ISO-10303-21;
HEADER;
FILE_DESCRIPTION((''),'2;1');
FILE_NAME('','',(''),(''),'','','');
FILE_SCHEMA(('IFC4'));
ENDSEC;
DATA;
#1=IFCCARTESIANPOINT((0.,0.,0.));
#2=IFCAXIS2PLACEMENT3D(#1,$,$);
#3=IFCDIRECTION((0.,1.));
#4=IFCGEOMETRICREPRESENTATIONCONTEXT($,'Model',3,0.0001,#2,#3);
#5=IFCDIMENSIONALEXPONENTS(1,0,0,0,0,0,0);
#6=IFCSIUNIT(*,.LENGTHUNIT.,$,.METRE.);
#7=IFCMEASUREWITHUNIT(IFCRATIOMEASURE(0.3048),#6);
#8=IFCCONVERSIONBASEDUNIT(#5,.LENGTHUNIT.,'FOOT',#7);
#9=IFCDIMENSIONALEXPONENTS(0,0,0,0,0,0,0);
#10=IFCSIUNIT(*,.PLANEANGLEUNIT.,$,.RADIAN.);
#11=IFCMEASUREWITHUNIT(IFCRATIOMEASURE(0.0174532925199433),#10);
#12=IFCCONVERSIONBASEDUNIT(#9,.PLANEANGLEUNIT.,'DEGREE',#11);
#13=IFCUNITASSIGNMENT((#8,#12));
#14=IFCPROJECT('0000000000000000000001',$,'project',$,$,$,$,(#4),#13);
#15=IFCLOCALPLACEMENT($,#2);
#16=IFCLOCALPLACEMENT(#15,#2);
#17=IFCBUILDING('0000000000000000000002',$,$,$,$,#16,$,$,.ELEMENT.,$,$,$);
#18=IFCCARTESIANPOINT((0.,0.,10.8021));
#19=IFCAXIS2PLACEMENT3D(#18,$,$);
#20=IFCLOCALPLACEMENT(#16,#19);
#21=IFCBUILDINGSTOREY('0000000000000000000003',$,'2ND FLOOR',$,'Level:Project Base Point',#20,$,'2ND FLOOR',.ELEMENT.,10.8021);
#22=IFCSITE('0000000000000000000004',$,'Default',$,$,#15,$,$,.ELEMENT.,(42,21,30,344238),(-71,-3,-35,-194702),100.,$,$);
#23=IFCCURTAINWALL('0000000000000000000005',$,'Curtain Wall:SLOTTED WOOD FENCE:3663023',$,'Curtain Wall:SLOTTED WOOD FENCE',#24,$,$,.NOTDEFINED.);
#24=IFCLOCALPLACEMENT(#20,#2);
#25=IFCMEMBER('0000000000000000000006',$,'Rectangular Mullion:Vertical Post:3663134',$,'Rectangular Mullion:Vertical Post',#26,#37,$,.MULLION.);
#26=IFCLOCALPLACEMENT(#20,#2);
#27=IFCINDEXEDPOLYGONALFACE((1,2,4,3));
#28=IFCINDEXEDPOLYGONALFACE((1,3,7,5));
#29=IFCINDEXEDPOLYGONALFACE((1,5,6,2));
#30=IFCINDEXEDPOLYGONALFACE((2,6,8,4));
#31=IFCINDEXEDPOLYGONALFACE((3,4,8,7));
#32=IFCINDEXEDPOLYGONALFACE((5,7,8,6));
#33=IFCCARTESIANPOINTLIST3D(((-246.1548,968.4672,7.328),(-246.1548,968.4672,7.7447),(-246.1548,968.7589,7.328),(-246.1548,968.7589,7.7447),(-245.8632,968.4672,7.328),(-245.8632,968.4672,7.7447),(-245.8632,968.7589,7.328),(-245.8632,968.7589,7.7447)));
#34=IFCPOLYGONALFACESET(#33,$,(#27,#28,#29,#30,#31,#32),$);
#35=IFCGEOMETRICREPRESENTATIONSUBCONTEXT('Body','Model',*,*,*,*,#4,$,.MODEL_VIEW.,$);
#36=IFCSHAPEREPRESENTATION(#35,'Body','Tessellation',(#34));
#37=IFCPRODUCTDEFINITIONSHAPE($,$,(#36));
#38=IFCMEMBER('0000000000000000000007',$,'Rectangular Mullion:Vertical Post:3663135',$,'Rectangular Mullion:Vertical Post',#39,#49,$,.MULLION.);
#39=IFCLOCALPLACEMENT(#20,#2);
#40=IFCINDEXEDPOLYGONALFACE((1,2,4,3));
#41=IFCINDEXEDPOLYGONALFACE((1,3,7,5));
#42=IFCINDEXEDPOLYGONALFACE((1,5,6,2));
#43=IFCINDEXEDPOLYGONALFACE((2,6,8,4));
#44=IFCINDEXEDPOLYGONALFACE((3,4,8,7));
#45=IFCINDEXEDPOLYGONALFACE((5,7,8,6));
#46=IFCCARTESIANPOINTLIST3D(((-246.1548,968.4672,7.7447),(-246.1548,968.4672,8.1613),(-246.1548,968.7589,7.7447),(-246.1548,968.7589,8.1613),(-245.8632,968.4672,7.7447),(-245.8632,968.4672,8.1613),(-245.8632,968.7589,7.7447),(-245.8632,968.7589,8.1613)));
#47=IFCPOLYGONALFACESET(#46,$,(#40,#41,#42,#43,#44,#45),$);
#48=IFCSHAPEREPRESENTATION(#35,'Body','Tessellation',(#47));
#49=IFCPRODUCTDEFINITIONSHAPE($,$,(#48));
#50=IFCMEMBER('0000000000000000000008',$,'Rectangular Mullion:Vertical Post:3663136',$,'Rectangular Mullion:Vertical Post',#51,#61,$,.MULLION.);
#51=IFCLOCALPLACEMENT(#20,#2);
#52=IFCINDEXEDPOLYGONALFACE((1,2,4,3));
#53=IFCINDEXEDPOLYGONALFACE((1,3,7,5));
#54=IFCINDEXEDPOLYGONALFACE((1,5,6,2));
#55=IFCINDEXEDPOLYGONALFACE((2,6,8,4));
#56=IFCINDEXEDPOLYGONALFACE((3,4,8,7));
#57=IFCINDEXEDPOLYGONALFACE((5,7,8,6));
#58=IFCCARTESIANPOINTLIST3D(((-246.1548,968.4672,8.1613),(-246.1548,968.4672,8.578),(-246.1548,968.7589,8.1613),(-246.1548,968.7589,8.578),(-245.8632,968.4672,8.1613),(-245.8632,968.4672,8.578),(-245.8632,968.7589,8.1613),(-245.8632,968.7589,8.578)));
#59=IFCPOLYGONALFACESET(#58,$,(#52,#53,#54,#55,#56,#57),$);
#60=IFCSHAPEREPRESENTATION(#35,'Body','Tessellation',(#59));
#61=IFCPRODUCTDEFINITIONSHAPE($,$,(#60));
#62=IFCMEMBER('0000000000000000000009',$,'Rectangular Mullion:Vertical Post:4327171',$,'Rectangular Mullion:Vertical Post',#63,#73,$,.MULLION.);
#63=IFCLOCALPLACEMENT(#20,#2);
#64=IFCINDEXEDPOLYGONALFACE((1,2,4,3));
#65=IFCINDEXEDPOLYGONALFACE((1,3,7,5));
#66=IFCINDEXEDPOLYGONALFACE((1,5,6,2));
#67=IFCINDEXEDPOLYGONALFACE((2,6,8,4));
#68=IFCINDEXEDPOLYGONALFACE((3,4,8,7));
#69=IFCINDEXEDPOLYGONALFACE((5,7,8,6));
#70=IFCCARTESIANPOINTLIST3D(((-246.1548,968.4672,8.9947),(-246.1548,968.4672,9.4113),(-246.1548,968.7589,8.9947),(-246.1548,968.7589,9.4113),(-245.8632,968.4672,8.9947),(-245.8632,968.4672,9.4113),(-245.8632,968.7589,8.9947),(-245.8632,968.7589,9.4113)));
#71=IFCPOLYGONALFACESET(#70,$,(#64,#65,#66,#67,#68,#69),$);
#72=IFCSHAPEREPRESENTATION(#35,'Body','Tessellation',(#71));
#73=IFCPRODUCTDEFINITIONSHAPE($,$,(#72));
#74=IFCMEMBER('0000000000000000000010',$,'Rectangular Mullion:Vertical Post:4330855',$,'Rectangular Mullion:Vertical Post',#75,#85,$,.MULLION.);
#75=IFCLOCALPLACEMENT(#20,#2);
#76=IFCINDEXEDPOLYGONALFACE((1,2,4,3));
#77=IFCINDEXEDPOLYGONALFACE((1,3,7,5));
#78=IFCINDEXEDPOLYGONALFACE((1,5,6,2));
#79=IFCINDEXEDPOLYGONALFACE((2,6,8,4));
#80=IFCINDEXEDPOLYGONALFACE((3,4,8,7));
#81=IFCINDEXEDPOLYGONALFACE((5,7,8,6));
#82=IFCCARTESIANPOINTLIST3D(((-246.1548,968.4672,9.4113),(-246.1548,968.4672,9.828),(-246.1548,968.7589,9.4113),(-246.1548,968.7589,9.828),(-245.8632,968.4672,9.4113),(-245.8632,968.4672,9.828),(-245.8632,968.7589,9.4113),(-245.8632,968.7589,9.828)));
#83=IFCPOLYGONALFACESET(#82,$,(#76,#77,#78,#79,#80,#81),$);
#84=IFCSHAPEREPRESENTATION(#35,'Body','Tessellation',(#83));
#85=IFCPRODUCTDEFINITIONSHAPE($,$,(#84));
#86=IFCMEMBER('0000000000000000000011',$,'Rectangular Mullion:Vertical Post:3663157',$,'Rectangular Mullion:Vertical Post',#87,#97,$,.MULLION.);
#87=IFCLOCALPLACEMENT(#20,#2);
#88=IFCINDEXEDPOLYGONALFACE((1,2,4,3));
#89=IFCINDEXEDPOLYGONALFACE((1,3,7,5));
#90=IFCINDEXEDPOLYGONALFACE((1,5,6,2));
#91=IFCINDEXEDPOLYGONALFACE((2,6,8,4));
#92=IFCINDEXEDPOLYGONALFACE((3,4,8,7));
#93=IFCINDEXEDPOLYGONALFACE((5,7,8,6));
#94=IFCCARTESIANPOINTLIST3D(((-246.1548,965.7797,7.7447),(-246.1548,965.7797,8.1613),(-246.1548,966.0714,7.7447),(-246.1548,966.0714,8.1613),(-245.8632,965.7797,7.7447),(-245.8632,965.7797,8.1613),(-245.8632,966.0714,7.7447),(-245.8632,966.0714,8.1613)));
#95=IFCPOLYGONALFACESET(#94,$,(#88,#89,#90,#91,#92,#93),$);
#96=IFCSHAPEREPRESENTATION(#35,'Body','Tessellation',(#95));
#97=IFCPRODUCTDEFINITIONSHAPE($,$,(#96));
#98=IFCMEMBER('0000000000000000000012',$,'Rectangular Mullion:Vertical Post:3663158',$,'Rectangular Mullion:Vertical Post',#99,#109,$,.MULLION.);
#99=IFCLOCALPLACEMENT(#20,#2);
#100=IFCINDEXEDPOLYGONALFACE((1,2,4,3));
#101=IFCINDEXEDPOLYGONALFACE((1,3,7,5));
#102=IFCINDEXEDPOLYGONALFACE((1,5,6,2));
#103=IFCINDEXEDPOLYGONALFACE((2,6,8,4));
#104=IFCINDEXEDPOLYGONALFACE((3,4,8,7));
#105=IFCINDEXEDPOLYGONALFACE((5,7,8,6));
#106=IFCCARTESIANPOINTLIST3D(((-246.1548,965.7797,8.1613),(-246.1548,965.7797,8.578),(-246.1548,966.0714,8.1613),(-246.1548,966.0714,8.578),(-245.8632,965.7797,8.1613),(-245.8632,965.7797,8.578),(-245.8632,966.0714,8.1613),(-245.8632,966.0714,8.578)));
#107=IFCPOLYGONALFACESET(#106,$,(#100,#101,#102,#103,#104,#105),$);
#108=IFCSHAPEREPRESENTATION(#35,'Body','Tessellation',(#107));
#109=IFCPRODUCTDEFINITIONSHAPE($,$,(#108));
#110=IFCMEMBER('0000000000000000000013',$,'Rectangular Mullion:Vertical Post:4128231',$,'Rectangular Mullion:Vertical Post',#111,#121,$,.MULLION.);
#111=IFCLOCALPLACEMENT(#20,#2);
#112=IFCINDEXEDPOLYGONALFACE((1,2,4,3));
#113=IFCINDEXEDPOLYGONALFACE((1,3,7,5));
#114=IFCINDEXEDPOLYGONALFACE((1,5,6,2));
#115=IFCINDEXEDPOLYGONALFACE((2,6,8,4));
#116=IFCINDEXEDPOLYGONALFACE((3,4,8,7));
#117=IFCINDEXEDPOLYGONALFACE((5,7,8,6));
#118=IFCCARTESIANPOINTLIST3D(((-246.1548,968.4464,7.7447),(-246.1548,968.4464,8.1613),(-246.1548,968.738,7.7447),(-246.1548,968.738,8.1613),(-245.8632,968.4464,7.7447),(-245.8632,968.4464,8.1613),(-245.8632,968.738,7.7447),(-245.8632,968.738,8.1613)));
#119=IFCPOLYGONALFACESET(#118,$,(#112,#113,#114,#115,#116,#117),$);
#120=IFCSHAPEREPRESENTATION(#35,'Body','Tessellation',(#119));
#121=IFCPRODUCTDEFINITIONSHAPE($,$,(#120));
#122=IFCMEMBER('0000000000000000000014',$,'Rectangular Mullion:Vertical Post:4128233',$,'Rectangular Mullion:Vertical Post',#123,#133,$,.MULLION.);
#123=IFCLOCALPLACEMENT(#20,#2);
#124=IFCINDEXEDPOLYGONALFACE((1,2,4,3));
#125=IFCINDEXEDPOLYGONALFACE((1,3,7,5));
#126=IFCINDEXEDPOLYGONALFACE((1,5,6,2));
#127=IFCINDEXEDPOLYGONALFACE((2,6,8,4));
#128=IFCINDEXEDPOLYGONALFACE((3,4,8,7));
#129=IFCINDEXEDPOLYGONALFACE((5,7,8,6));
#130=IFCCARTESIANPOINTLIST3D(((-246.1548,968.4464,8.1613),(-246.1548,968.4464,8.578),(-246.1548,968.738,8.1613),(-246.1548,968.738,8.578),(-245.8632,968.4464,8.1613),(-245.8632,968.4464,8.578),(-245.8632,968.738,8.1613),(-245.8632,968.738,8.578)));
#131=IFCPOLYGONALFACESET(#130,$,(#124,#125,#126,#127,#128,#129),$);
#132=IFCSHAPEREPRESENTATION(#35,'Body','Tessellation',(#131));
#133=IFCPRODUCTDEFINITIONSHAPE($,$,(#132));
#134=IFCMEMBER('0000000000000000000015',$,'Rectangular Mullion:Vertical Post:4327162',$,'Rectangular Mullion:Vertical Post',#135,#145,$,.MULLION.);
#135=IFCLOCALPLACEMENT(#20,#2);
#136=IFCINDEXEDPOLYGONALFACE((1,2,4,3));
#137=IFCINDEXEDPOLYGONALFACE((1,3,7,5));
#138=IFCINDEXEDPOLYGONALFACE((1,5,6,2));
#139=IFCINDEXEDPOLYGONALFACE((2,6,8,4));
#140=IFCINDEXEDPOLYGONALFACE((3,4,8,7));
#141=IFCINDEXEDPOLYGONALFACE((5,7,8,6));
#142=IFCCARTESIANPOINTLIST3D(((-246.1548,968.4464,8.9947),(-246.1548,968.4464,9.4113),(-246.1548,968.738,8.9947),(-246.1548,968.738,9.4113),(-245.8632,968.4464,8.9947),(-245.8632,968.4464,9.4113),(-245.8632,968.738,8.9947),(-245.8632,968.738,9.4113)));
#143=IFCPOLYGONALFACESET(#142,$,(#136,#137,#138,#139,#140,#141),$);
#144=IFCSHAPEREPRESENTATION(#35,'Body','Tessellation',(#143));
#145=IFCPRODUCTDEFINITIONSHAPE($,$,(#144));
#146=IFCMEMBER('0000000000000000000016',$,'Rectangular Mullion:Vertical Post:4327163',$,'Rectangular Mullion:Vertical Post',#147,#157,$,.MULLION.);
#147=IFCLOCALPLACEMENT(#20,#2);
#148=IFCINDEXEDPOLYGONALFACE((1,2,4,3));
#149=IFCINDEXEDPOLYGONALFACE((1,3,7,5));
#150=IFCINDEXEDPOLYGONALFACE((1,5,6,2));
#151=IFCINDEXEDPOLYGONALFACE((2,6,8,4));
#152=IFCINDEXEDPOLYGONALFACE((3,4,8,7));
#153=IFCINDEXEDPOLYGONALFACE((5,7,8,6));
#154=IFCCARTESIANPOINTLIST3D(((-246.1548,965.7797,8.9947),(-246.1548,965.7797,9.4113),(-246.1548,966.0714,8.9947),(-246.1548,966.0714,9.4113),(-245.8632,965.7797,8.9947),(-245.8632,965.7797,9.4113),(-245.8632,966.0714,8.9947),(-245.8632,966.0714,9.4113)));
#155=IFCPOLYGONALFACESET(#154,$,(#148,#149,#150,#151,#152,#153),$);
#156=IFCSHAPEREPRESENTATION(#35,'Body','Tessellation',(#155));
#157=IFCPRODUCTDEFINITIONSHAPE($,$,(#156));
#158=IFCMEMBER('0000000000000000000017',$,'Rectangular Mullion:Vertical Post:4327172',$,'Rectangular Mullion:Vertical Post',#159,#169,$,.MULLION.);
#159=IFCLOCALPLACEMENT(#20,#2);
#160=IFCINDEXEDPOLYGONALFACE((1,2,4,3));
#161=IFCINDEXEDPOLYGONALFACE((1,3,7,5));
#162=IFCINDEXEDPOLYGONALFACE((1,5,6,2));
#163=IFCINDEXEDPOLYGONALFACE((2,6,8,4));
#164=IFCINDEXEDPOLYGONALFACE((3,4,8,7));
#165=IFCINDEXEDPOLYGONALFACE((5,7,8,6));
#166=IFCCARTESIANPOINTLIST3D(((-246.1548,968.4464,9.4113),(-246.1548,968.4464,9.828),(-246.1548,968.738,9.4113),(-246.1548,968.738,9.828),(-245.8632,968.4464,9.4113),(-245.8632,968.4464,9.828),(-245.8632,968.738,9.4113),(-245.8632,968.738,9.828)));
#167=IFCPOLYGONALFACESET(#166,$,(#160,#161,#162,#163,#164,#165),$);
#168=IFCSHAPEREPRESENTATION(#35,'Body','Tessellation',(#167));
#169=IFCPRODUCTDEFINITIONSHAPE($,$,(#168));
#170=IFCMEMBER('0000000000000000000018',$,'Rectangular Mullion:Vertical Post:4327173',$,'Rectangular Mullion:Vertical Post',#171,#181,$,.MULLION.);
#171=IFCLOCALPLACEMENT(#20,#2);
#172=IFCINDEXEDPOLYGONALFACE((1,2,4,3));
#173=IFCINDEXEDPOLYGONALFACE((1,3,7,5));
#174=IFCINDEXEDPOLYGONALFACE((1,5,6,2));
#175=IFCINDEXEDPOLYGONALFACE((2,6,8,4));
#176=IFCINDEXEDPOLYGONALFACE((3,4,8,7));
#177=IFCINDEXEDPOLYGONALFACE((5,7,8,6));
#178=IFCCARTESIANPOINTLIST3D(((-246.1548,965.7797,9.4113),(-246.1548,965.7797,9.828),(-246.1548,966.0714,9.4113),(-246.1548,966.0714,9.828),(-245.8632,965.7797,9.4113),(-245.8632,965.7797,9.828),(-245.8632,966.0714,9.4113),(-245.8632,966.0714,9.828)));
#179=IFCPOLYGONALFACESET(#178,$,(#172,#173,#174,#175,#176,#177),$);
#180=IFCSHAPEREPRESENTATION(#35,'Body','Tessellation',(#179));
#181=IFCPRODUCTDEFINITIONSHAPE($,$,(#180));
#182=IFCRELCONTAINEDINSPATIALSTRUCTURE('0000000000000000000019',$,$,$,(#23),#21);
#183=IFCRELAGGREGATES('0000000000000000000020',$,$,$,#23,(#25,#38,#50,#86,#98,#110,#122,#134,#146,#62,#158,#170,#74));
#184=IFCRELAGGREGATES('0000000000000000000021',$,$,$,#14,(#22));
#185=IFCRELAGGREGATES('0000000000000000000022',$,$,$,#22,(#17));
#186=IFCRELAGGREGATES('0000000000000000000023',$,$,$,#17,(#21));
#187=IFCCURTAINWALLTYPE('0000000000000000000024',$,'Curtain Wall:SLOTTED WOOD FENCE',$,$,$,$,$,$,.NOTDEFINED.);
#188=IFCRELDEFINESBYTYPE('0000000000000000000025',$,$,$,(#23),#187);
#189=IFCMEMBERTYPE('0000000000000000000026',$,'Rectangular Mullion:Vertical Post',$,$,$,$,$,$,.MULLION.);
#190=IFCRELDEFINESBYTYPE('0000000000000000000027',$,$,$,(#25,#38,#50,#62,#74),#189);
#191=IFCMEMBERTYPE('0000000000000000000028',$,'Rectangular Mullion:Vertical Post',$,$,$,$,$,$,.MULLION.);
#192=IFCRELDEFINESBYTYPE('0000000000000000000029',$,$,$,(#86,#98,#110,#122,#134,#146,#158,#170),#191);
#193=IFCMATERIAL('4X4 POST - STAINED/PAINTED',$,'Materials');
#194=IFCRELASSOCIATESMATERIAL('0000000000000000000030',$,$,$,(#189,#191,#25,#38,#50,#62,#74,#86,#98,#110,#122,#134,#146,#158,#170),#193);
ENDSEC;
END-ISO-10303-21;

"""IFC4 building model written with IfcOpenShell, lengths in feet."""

from ifc_helpers import new_model, entity, si_unit, converted_unit, direction, frame, origin, origin_2d_with_axis, place, context, subcontext, project, spatial, rectangle, extrude, source, transform, mapped, material, material_profile, profile_set, profile_usage, type_object, type_shapes, element, aggregate, save


model = new_model("IFC4")

# Units and contexts
model_context = context("Model", 3, precision=0.0001, world=origin(), true_north=direction((0.0, 1.0)))
body_context = subcontext(model_context, "Body", "Model", "MODEL_VIEW")
ifc_project = project(units=[converted_unit("LENGTHUNIT", "FOOT", entity("IfcRatioMeasure", 0.3048), si_unit("LENGTHUNIT", "METRE"), dimensions=[1, 0, 0, 0, 0, 0, 0]), converted_unit("PLANEANGLEUNIT", "DEGREE", entity("IfcRatioMeasure", 0.0174532925199433), si_unit("PLANEANGLEUNIT", "RADIAN"), dimensions=[0, 0, 0, 0, 0, 0, 0])], contexts=[model_context])

# Site, building, storey
site_placement = place(None, origin())
site = spatial("IfcSite", under=ifc_project, at=site_placement, Name="Default", CompositionType="ELEMENT", RefLatitude=(42, 21, 30, 344238), RefLongitude=(-71, -3, -35, -194702), RefElevation=100.0)
building_placement = place(site_placement, origin())
building = spatial("IfcBuilding", under=site, at=building_placement, CompositionType="ELEMENT")
storey_placement = place(building_placement, frame((0.0, 0.0, 10.8021)))
storey = spatial("IfcBuildingStorey", under=building, at=storey_placement, Name="2ND FLOOR", ObjectType="Level:Project Base Point", LongName="2ND FLOOR", CompositionType="ELEMENT", Elevation=10.8021)

# Curtain wall, members
curtain_wall_type = type_object("IfcCurtainWallType", Name="Curtain Wall:SLOTTED WOOD FENCE", PredefinedType="NOTDEFINED")
curtain_wall_placement = place(storey_placement, frame((0.0, 0.0, -10.8021)))
curtain_wall = element("IfcCurtainWall", 1, at=curtain_wall_placement, inside=storey, type_object=curtain_wall_type, Name="Curtain Wall:SLOTTED WOOD FENCE:3663023", ObjectType="Curtain Wall:SLOTTED WOOD FENCE", PredefinedType="NOTDEFINED")
ifc_material_1 = material(Name="4X4 POST - STAINED/PAINTED", Category="Materials")
ifc_material_profile = material_profile(ifc_material_1, rectangle(XDim=0.2917, YDim=0.2917, at=origin_2d_with_axis()), Name="Vertical Post")
ifc_profile_set = profile_set([ifc_material_profile], Name="Vertical Post")
ifc_profile_usage_1 = profile_usage(ifc_profile_set)
member_type_1 = type_object("IfcMemberType", Name="Rectangular Mullion:Vertical Post", PredefinedType="MULLION", material=ifc_profile_set)
shared_shape_1 = source(origin(), body_context, "Body", "SweptSolid", [
    extrude(rectangle(XDim=0.2917, YDim=0.2917, at=origin_2d_with_axis()), frame((-0.1458, 0.2083, -0.4167), z_axis=(0.0, 0.0, 1.0), x_axis=(0.0, -1.0, 0.0)), (0.0, 0.0, 1.0), 0.4167),
])
type_shapes(member_type_1, [shared_shape_1])
member_1_placement = place(storey_placement, frame((-245.8007, 968.7589, 7.7447), z_axis=(0.0, 0.0, 1.0), x_axis=(0.0, 1.0, 0.0)))
member_1 = element("IfcMember", 2, at=member_1_placement, type_object=member_type_1, material=ifc_profile_usage_1, Name="Rectangular Mullion:Vertical Post:3663134", ObjectType="Rectangular Mullion:Vertical Post", PredefinedType="MULLION", context=body_context, shape_type="MappedRepresentation", body=[
    mapped(shared_shape_1, transform((0.0, 0.0, 0.0), scale=1.0)),
])
ifc_profile_usage_2 = profile_usage(ifc_profile_set)
member_2_placement = place(storey_placement, frame((-245.8007, 968.7589, 8.1613), z_axis=(0.0, 0.0, 1.0), x_axis=(0.0, 1.0, 0.0)))
member_2 = element("IfcMember", 3, at=member_2_placement, type_object=member_type_1, material=ifc_profile_usage_2, Name="Rectangular Mullion:Vertical Post:3663135", ObjectType="Rectangular Mullion:Vertical Post", PredefinedType="MULLION", context=body_context, shape_type="MappedRepresentation", body=[
    mapped(shared_shape_1, transform((0.0, 0.0, 0.0), scale=1.0)),
])
ifc_profile_usage_3 = profile_usage(ifc_profile_set)
member_3_placement = place(storey_placement, frame((-245.8007, 968.7589, 8.578), z_axis=(0.0, 0.0, 1.0), x_axis=(0.0, 1.0, 0.0)))
member_3 = element("IfcMember", 4, at=member_3_placement, type_object=member_type_1, material=ifc_profile_usage_3, Name="Rectangular Mullion:Vertical Post:3663136", ObjectType="Rectangular Mullion:Vertical Post", PredefinedType="MULLION", context=body_context, shape_type="MappedRepresentation", body=[
    mapped(shared_shape_1, transform((0.0, 0.0, 0.0), scale=1.0)),
])
ifc_profile_usage_4 = profile_usage(ifc_profile_set)
member_4_placement = place(storey_placement, frame((-245.8007, 968.7589, 9.4113), z_axis=(0.0, 0.0, 1.0), x_axis=(0.0, 1.0, 0.0)))
member_4 = element("IfcMember", 5, at=member_4_placement, type_object=member_type_1, material=ifc_profile_usage_4, Name="Rectangular Mullion:Vertical Post:4327171", ObjectType="Rectangular Mullion:Vertical Post", PredefinedType="MULLION", context=body_context, shape_type="MappedRepresentation", body=[
    mapped(shared_shape_1, transform((0.0, 0.0, 0.0), scale=1.0)),
])
ifc_profile_usage_5 = profile_usage(ifc_profile_set)
member_5_placement = place(storey_placement, frame((-245.8007, 968.7589, 9.828), z_axis=(0.0, 0.0, 1.0), x_axis=(0.0, 1.0, 0.0)))
member_5 = element("IfcMember", 6, at=member_5_placement, type_object=member_type_1, material=ifc_profile_usage_5, Name="Rectangular Mullion:Vertical Post:4330855", ObjectType="Rectangular Mullion:Vertical Post", PredefinedType="MULLION", context=body_context, shape_type="MappedRepresentation", body=[
    mapped(shared_shape_1, transform((0.0, 0.0, 0.0), scale=1.0)),
])
ifc_profile_usage_6 = profile_usage(ifc_profile_set)
member_type_2 = type_object("IfcMemberType", Name="Rectangular Mullion:Vertical Post", PredefinedType="MULLION", material=ifc_profile_set)
shared_shape_2 = source(origin(), body_context, "Body", "SweptSolid", [
    extrude(rectangle(XDim=0.2917, YDim=0.2917, at=origin_2d_with_axis()), frame((0.0, 0.2083, -0.4167), z_axis=(0.0, 0.0, 1.0), x_axis=(0.0, -1.0, 0.0)), (0.0, 0.0, 1.0), 0.4167),
])
type_shapes(member_type_2, [shared_shape_2])
member_6_placement = place(storey_placement, frame((-245.8007, 965.9255, 7.7447), z_axis=(0.0, 0.0, -1.0), x_axis=(0.0, -1.0, 0.0)))
member_6 = element("IfcMember", 7, at=member_6_placement, type_object=member_type_2, material=ifc_profile_usage_6, Name="Rectangular Mullion:Vertical Post:3663157", ObjectType="Rectangular Mullion:Vertical Post", PredefinedType="MULLION", context=body_context, shape_type="MappedRepresentation", body=[
    mapped(shared_shape_2, transform((0.0, 0.0, 0.0), scale=1.0)),
])
ifc_profile_usage_7 = profile_usage(ifc_profile_set)
member_7_placement = place(storey_placement, frame((-245.8007, 965.9255, 8.1613), z_axis=(0.0, 0.0, -1.0), x_axis=(0.0, -1.0, 0.0)))
member_7 = element("IfcMember", 8, at=member_7_placement, type_object=member_type_2, material=ifc_profile_usage_7, Name="Rectangular Mullion:Vertical Post:3663158", ObjectType="Rectangular Mullion:Vertical Post", PredefinedType="MULLION", context=body_context, shape_type="MappedRepresentation", body=[
    mapped(shared_shape_2, transform((0.0, 0.0, 0.0), scale=1.0)),
])
ifc_profile_usage_8 = profile_usage(ifc_profile_set)
member_8_placement = place(storey_placement, frame((-245.8007, 968.5922, 7.7447), z_axis=(0.0, 0.0, -1.0), x_axis=(0.0, -1.0, 0.0)))
member_8 = element("IfcMember", 9, at=member_8_placement, type_object=member_type_2, material=ifc_profile_usage_8, Name="Rectangular Mullion:Vertical Post:4128231", ObjectType="Rectangular Mullion:Vertical Post", PredefinedType="MULLION", context=body_context, shape_type="MappedRepresentation", body=[
    mapped(shared_shape_2, transform((0.0, 0.0, 0.0), scale=1.0)),
])
ifc_profile_usage_9 = profile_usage(ifc_profile_set)
member_9_placement = place(storey_placement, frame((-245.8007, 968.5922, 8.1613), z_axis=(0.0, 0.0, -1.0), x_axis=(0.0, -1.0, 0.0)))
member_9 = element("IfcMember", 10, at=member_9_placement, type_object=member_type_2, material=ifc_profile_usage_9, Name="Rectangular Mullion:Vertical Post:4128233", ObjectType="Rectangular Mullion:Vertical Post", PredefinedType="MULLION", context=body_context, shape_type="MappedRepresentation", body=[
    mapped(shared_shape_2, transform((0.0, 0.0, 0.0), scale=1.0)),
])
ifc_profile_usage_10 = profile_usage(ifc_profile_set)
member_10_placement = place(storey_placement, frame((-245.8007, 968.5922, 8.9947), z_axis=(0.0, 0.0, -1.0), x_axis=(0.0, -1.0, 0.0)))
member_10 = element("IfcMember", 11, at=member_10_placement, type_object=member_type_2, material=ifc_profile_usage_10, Name="Rectangular Mullion:Vertical Post:4327162", ObjectType="Rectangular Mullion:Vertical Post", PredefinedType="MULLION", context=body_context, shape_type="MappedRepresentation", body=[
    mapped(shared_shape_2, transform((0.0, 0.0, 0.0), scale=1.0)),
])
ifc_profile_usage_11 = profile_usage(ifc_profile_set)
member_11_placement = place(storey_placement, frame((-245.8007, 965.9255, 8.9947), z_axis=(0.0, 0.0, -1.0), x_axis=(0.0, -1.0, 0.0)))
member_11 = element("IfcMember", 12, at=member_11_placement, type_object=member_type_2, material=ifc_profile_usage_11, Name="Rectangular Mullion:Vertical Post:4327163", ObjectType="Rectangular Mullion:Vertical Post", PredefinedType="MULLION", context=body_context, shape_type="MappedRepresentation", body=[
    mapped(shared_shape_2, transform((0.0, 0.0, 0.0), scale=1.0)),
])
ifc_profile_usage_12 = profile_usage(ifc_profile_set)
member_12_placement = place(storey_placement, frame((-245.8007, 968.5922, 9.4113), z_axis=(0.0, 0.0, -1.0), x_axis=(0.0, -1.0, 0.0)))
member_12 = element("IfcMember", 13, at=member_12_placement, type_object=member_type_2, material=ifc_profile_usage_12, Name="Rectangular Mullion:Vertical Post:4327172", ObjectType="Rectangular Mullion:Vertical Post", PredefinedType="MULLION", context=body_context, shape_type="MappedRepresentation", body=[
    mapped(shared_shape_2, transform((0.0, 0.0, 0.0), scale=1.0)),
])
ifc_profile_usage_13 = profile_usage(ifc_profile_set)
member_13_placement = place(storey_placement, frame((-245.8007, 965.9255, 9.4113), z_axis=(0.0, 0.0, -1.0), x_axis=(0.0, -1.0, 0.0)))
member_13 = element("IfcMember", 14, at=member_13_placement, type_object=member_type_2, material=ifc_profile_usage_13, Name="Rectangular Mullion:Vertical Post:4327173", ObjectType="Rectangular Mullion:Vertical Post", PredefinedType="MULLION", context=body_context, shape_type="MappedRepresentation", body=[
    mapped(shared_shape_2, transform((0.0, 0.0, 0.0), scale=1.0)),
])
aggregate(curtain_wall, [member_1, member_2, member_3, member_6, member_7, member_8, member_9, member_10, member_11, member_4, member_12, member_13, member_5])

save(model, "model.ifc")
